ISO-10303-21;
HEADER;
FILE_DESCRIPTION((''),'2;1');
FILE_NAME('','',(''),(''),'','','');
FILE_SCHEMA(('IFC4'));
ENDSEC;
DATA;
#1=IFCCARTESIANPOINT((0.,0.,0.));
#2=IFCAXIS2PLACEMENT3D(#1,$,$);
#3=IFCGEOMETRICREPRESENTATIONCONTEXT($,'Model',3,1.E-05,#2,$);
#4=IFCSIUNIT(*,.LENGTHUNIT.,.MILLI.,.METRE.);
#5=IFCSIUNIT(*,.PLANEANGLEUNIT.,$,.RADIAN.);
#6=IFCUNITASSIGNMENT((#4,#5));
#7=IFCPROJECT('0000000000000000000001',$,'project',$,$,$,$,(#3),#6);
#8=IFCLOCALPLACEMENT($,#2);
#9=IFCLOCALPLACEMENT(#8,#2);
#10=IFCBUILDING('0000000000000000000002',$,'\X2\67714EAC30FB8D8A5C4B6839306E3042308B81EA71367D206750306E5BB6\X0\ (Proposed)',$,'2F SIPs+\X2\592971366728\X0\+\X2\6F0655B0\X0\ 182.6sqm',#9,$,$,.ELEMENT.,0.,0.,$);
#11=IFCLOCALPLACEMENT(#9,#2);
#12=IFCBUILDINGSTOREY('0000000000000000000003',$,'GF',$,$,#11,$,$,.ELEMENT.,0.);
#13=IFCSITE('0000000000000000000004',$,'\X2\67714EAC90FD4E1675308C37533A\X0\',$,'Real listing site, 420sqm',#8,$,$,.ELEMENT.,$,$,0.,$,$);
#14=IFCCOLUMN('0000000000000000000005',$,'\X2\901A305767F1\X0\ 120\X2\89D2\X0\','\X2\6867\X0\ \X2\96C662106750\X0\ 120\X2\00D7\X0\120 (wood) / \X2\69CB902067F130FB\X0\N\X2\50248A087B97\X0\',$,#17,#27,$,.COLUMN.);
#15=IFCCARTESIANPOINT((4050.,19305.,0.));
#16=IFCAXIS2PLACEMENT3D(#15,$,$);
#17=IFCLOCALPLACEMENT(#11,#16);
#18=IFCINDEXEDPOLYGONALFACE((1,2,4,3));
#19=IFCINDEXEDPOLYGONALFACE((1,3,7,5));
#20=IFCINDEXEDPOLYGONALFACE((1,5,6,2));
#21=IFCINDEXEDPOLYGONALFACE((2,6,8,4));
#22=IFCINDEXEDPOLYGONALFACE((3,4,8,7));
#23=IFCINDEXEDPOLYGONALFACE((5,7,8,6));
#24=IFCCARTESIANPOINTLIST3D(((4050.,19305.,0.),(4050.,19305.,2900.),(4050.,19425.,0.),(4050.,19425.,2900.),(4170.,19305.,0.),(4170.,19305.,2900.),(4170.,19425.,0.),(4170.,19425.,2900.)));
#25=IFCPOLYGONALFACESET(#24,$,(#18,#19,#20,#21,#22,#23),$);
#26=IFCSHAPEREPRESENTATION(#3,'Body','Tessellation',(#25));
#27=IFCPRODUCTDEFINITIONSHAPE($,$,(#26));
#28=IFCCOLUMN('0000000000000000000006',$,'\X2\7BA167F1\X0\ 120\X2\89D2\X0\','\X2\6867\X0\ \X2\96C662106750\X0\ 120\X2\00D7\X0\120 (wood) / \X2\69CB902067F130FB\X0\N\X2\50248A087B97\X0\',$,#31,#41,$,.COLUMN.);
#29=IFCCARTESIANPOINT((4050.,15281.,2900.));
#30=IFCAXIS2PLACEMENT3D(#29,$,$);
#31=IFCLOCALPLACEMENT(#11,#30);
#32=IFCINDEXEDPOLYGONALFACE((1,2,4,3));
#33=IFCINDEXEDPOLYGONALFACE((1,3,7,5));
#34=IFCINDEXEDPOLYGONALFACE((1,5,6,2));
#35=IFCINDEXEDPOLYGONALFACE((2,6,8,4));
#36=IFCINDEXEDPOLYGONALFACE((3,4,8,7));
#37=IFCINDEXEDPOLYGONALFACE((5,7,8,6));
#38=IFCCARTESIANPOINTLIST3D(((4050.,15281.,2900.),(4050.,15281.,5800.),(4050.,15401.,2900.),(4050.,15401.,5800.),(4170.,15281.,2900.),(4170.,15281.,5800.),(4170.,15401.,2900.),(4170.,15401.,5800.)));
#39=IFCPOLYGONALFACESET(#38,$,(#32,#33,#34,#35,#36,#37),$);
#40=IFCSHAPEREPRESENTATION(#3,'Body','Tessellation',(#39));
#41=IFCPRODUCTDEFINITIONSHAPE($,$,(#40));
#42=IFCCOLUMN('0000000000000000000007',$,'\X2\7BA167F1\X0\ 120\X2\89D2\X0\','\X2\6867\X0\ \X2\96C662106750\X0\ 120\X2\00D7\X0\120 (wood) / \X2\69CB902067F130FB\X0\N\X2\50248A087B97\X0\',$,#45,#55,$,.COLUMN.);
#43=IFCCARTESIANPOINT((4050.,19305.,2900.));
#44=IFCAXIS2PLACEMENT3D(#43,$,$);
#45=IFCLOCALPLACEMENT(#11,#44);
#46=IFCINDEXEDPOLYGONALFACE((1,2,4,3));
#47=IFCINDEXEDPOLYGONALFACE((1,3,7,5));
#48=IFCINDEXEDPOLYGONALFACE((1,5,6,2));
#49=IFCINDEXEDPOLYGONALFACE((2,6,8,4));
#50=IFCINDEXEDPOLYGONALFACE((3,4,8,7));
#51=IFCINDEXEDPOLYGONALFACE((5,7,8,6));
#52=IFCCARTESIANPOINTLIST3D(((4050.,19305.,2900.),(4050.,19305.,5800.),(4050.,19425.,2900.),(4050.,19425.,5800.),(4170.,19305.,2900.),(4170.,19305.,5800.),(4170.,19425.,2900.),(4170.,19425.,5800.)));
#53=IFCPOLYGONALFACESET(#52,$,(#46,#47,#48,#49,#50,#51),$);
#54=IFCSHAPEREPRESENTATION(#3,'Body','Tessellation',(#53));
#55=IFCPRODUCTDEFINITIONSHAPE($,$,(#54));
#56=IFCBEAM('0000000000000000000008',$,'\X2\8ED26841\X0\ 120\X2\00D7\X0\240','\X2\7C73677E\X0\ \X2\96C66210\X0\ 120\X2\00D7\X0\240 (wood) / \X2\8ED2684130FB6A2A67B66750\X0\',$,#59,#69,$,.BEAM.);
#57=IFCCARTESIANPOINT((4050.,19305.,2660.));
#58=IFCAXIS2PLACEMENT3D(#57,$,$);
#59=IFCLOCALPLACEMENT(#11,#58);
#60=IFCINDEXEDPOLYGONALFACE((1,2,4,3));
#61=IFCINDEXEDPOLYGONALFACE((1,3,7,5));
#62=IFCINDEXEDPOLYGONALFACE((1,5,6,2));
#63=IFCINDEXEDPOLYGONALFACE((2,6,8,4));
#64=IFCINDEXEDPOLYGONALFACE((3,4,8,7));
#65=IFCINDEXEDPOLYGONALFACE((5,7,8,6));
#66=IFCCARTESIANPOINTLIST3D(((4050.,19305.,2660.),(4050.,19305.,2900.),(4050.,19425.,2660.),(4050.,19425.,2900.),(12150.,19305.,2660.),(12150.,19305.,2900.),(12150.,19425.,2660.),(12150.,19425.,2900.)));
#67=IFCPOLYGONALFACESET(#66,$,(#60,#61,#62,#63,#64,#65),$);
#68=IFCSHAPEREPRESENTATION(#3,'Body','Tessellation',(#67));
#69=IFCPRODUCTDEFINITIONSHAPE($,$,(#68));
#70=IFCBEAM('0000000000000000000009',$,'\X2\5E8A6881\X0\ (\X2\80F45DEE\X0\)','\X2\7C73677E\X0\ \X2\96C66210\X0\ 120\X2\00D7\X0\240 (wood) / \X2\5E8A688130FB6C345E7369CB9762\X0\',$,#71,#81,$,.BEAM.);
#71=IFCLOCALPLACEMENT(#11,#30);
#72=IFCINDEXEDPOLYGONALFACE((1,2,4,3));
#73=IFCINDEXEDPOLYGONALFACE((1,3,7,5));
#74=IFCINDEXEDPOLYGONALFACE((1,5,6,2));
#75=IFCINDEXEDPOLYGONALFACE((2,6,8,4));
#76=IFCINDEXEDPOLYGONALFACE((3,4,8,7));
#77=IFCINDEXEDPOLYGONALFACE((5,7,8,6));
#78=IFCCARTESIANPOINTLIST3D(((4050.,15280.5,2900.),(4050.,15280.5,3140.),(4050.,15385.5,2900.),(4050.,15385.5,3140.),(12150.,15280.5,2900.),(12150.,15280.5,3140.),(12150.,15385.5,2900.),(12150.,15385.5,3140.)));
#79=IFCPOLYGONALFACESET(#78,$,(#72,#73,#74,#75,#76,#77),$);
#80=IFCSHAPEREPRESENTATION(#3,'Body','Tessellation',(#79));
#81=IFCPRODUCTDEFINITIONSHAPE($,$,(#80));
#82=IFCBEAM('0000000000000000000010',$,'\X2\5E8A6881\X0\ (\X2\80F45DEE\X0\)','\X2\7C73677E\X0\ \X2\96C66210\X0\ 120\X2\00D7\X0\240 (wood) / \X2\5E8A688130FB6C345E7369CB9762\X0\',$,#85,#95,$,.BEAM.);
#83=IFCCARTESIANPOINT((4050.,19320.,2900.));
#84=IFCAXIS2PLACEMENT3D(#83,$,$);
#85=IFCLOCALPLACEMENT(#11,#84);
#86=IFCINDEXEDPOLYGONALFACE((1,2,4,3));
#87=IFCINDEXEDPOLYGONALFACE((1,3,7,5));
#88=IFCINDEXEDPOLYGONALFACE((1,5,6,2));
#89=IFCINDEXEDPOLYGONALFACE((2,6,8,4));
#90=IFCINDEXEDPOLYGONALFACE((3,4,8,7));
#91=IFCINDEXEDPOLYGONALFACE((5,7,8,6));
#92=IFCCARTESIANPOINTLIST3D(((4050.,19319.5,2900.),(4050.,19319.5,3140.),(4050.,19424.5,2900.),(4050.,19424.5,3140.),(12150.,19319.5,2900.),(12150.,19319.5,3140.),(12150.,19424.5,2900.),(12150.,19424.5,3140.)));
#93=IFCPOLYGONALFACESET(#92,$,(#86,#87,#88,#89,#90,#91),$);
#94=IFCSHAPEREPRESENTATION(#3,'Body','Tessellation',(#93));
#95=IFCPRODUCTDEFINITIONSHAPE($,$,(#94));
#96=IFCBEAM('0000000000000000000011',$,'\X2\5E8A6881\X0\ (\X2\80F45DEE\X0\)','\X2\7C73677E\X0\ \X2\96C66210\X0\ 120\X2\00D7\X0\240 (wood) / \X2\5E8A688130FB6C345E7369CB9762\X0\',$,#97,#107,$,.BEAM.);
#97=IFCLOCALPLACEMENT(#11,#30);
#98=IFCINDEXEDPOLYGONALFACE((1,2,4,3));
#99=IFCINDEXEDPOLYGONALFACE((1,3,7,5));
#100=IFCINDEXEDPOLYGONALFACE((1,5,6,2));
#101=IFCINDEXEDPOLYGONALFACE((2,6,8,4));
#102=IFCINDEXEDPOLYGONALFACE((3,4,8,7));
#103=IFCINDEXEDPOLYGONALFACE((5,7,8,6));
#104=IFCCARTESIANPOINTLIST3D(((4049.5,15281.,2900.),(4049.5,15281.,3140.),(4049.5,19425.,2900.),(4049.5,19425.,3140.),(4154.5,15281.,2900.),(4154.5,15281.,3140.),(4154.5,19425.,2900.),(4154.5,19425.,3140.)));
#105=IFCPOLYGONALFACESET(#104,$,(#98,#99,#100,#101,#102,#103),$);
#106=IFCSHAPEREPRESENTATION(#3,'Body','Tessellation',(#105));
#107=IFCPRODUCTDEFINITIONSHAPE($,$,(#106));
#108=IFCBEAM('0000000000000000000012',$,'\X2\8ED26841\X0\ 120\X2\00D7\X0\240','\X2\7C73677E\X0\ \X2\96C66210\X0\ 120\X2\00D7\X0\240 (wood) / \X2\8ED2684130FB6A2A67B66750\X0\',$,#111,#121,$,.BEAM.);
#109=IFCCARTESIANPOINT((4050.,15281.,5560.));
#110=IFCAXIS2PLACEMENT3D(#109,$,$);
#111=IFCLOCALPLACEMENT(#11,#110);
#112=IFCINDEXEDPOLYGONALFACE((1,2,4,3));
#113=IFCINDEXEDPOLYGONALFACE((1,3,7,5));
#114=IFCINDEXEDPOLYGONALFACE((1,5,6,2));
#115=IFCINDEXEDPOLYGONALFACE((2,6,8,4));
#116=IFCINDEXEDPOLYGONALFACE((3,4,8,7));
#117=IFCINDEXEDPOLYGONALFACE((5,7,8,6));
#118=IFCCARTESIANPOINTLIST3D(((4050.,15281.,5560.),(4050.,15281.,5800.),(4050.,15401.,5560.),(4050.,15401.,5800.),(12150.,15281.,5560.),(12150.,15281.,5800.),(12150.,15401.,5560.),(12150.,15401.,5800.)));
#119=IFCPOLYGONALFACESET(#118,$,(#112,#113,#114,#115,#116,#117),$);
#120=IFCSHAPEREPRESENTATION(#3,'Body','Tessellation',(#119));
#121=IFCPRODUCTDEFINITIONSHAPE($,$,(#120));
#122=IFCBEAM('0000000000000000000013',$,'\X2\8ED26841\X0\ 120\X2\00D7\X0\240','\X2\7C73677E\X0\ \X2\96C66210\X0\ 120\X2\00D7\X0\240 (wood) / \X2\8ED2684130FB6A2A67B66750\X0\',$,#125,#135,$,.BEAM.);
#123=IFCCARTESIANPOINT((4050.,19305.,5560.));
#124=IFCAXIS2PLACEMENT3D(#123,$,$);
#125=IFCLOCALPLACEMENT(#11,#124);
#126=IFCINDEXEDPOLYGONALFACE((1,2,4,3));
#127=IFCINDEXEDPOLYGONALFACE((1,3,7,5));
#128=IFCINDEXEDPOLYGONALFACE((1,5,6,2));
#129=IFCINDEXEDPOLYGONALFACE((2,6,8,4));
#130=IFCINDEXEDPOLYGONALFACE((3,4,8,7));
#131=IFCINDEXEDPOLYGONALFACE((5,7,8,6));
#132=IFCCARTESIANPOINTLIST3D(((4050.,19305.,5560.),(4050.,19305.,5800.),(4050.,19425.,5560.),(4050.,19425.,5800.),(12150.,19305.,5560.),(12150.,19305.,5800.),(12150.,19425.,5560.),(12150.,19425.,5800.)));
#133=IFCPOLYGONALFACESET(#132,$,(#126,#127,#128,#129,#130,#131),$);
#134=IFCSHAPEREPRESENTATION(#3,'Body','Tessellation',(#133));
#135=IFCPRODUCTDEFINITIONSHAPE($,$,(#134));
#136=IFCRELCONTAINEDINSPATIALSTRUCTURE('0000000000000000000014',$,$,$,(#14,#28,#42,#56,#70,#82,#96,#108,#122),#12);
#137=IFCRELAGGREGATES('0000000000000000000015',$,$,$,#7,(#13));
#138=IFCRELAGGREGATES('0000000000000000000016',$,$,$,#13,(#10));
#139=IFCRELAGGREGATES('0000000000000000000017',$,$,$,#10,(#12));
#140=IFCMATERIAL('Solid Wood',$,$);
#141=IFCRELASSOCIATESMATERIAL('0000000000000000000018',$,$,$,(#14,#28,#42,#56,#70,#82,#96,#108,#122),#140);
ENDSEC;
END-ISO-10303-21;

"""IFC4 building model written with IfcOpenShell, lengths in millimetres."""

from ifc_helpers import new_model, si_unit, frame, frame_2d, origin, place, context, project, spatial, rectangle, extrude, material, element, save


model = new_model("IFC4")

# Units and contexts
model_context = context("Model", 3, precision=1e-05, world=origin())
ifc_project = project(units=[si_unit("LENGTHUNIT", "METRE", prefix="MILLI"), si_unit("PLANEANGLEUNIT", "RADIAN")], contexts=[model_context])

# Site, building, storey
site_placement = place(None, origin())
site = spatial("IfcSite", under=ifc_project, at=site_placement, Name="東京都世田谷区", ObjectType="Real listing site, 420sqm", CompositionType="ELEMENT", RefElevation=0.0)
building_placement = place(site_placement, origin())
building = spatial("IfcBuilding", under=site, at=building_placement, Name="東京・越屋根のある自然素材の家 (Proposed)", ObjectType="2F SIPs+天然木+漆喰 182.6sqm", CompositionType="ELEMENT", ElevationOfRefHeight=0.0, ElevationOfTerrain=0.0)
storey_placement = place(building_placement, origin())
storey = spatial("IfcBuildingStorey", under=building, at=storey_placement, Name="GF", CompositionType="ELEMENT", Elevation=0.0)

# Columns
ifc_material_1 = material(Name="Solid Wood")
column_1_placement = place(storey_placement, frame((4050.0, 19305.0, 0.0)))
element("IfcColumn", 1, at=column_1_placement, inside=storey, material=ifc_material_1, Name="通し柱 120角", Description="桧 集成材 120×120 (wood) / 構造柱・N値計算", PredefinedType="COLUMN", context=model_context, shape_type="SweptSolid", body=[
    extrude(rectangle(XDim=120.0, YDim=120.0, at=frame_2d((60.0, 60.0))), frame((4050.0, 19305.0, 0.0)), (0.0, 0.0, 1.0), 2900.0),
])
column_2_placement = place(storey_placement, frame((4050.0, 15281.0, 2900.0)))
element("IfcColumn", 2, at=column_2_placement, inside=storey, material=ifc_material_1, Name="管柱 120角", Description="桧 集成材 120×120 (wood) / 構造柱・N値計算", PredefinedType="COLUMN", context=model_context, shape_type="SweptSolid", body=[
    extrude(rectangle(XDim=120.0, YDim=120.0, at=frame_2d((60.0, 60.0))), frame((4050.0, 15281.0, 2900.0)), (0.0, 0.0, 1.0), 2900.0),
])
column_3_placement = place(storey_placement, frame((4050.0, 19305.0, 2900.0)))
element("IfcColumn", 3, at=column_3_placement, inside=storey, material=ifc_material_1, Name="管柱 120角", Description="桧 集成材 120×120 (wood) / 構造柱・N値計算", PredefinedType="COLUMN", context=model_context, shape_type="SweptSolid", body=[
    extrude(rectangle(XDim=120.0, YDim=120.0, at=frame_2d((60.0, 60.0))), frame((4050.0, 19305.0, 2900.0)), (0.0, 0.0, 1.0), 2900.0),
])

# Beams
beam_1_placement = place(storey_placement, frame((4050.0, 19305.0, 2660.0)))
element("IfcBeam", 4, at=beam_1_placement, inside=storey, material=ifc_material_1, Name="軒桁 120×240", Description="米松 集成 120×240 (wood) / 軒桁・横架材", PredefinedType="BEAM", context=model_context, shape_type="SweptSolid", body=[
    extrude(rectangle(XDim=8100.0, YDim=120.0, at=frame_2d((4050.0, 60.0))), frame((4050.0, 19305.0, 2660.0)), (0.0, 0.0, 1.0), 240.0),
])
beam_2_placement = place(storey_placement, frame((4050.0, 15281.0, 2900.0)))
element("IfcBeam", 5, at=beam_2_placement, inside=storey, material=ifc_material_1, Name="床梁 (胴差)", Description="米松 集成 120×240 (wood) / 床梁・水平構面", PredefinedType="BEAM", context=model_context, shape_type="SweptSolid", body=[
    extrude(rectangle(XDim=8100.0, YDim=105.0, at=frame_2d((4050.0, 52.0))), frame((4050.0, 15281.0, 2900.0)), (0.0, 0.0, 1.0), 240.0),
])
beam_3_placement = place(storey_placement, frame((4050.0, 19320.0, 2900.0)))
element("IfcBeam", 6, at=beam_3_placement, inside=storey, material=ifc_material_1, Name="床梁 (胴差)", Description="米松 集成 120×240 (wood) / 床梁・水平構面", PredefinedType="BEAM", context=model_context, shape_type="SweptSolid", body=[
    extrude(rectangle(XDim=8100.0, YDim=105.0, at=frame_2d((4050.0, 52.0))), frame((4050.0, 19320.0, 2900.0)), (0.0, 0.0, 1.0), 240.0),
])
beam_4_placement = place(storey_placement, frame((4050.0, 15281.0, 2900.0)))
element("IfcBeam", 7, at=beam_4_placement, inside=storey, material=ifc_material_1, Name="床梁 (胴差)", Description="米松 集成 120×240 (wood) / 床梁・水平構面", PredefinedType="BEAM", context=model_context, shape_type="SweptSolid", body=[
    extrude(rectangle(XDim=105.0, YDim=4144.0, at=frame_2d((52.0, 2072.0))), frame((4050.0, 15281.0, 2900.0)), (0.0, 0.0, 1.0), 240.0),
])
beam_5_placement = place(storey_placement, frame((4050.0, 15281.0, 5560.0)))
element("IfcBeam", 8, at=beam_5_placement, inside=storey, material=ifc_material_1, Name="軒桁 120×240", Description="米松 集成 120×240 (wood) / 軒桁・横架材", PredefinedType="BEAM", context=model_context, shape_type="SweptSolid", body=[
    extrude(rectangle(XDim=8100.0, YDim=120.0, at=frame_2d((4050.0, 60.0))), frame((4050.0, 15281.0, 5560.0)), (0.0, 0.0, 1.0), 240.0),
])
beam_6_placement = place(storey_placement, frame((4050.0, 19305.0, 5560.0)))
element("IfcBeam", 9, at=beam_6_placement, inside=storey, material=ifc_material_1, Name="軒桁 120×240", Description="米松 集成 120×240 (wood) / 軒桁・横架材", PredefinedType="BEAM", context=model_context, shape_type="SweptSolid", body=[
    extrude(rectangle(XDim=8100.0, YDim=120.0, at=frame_2d((4050.0, 60.0))), frame((4050.0, 19305.0, 5560.0)), (0.0, 0.0, 1.0), 240.0),
])

save(model, "model.ifc")
